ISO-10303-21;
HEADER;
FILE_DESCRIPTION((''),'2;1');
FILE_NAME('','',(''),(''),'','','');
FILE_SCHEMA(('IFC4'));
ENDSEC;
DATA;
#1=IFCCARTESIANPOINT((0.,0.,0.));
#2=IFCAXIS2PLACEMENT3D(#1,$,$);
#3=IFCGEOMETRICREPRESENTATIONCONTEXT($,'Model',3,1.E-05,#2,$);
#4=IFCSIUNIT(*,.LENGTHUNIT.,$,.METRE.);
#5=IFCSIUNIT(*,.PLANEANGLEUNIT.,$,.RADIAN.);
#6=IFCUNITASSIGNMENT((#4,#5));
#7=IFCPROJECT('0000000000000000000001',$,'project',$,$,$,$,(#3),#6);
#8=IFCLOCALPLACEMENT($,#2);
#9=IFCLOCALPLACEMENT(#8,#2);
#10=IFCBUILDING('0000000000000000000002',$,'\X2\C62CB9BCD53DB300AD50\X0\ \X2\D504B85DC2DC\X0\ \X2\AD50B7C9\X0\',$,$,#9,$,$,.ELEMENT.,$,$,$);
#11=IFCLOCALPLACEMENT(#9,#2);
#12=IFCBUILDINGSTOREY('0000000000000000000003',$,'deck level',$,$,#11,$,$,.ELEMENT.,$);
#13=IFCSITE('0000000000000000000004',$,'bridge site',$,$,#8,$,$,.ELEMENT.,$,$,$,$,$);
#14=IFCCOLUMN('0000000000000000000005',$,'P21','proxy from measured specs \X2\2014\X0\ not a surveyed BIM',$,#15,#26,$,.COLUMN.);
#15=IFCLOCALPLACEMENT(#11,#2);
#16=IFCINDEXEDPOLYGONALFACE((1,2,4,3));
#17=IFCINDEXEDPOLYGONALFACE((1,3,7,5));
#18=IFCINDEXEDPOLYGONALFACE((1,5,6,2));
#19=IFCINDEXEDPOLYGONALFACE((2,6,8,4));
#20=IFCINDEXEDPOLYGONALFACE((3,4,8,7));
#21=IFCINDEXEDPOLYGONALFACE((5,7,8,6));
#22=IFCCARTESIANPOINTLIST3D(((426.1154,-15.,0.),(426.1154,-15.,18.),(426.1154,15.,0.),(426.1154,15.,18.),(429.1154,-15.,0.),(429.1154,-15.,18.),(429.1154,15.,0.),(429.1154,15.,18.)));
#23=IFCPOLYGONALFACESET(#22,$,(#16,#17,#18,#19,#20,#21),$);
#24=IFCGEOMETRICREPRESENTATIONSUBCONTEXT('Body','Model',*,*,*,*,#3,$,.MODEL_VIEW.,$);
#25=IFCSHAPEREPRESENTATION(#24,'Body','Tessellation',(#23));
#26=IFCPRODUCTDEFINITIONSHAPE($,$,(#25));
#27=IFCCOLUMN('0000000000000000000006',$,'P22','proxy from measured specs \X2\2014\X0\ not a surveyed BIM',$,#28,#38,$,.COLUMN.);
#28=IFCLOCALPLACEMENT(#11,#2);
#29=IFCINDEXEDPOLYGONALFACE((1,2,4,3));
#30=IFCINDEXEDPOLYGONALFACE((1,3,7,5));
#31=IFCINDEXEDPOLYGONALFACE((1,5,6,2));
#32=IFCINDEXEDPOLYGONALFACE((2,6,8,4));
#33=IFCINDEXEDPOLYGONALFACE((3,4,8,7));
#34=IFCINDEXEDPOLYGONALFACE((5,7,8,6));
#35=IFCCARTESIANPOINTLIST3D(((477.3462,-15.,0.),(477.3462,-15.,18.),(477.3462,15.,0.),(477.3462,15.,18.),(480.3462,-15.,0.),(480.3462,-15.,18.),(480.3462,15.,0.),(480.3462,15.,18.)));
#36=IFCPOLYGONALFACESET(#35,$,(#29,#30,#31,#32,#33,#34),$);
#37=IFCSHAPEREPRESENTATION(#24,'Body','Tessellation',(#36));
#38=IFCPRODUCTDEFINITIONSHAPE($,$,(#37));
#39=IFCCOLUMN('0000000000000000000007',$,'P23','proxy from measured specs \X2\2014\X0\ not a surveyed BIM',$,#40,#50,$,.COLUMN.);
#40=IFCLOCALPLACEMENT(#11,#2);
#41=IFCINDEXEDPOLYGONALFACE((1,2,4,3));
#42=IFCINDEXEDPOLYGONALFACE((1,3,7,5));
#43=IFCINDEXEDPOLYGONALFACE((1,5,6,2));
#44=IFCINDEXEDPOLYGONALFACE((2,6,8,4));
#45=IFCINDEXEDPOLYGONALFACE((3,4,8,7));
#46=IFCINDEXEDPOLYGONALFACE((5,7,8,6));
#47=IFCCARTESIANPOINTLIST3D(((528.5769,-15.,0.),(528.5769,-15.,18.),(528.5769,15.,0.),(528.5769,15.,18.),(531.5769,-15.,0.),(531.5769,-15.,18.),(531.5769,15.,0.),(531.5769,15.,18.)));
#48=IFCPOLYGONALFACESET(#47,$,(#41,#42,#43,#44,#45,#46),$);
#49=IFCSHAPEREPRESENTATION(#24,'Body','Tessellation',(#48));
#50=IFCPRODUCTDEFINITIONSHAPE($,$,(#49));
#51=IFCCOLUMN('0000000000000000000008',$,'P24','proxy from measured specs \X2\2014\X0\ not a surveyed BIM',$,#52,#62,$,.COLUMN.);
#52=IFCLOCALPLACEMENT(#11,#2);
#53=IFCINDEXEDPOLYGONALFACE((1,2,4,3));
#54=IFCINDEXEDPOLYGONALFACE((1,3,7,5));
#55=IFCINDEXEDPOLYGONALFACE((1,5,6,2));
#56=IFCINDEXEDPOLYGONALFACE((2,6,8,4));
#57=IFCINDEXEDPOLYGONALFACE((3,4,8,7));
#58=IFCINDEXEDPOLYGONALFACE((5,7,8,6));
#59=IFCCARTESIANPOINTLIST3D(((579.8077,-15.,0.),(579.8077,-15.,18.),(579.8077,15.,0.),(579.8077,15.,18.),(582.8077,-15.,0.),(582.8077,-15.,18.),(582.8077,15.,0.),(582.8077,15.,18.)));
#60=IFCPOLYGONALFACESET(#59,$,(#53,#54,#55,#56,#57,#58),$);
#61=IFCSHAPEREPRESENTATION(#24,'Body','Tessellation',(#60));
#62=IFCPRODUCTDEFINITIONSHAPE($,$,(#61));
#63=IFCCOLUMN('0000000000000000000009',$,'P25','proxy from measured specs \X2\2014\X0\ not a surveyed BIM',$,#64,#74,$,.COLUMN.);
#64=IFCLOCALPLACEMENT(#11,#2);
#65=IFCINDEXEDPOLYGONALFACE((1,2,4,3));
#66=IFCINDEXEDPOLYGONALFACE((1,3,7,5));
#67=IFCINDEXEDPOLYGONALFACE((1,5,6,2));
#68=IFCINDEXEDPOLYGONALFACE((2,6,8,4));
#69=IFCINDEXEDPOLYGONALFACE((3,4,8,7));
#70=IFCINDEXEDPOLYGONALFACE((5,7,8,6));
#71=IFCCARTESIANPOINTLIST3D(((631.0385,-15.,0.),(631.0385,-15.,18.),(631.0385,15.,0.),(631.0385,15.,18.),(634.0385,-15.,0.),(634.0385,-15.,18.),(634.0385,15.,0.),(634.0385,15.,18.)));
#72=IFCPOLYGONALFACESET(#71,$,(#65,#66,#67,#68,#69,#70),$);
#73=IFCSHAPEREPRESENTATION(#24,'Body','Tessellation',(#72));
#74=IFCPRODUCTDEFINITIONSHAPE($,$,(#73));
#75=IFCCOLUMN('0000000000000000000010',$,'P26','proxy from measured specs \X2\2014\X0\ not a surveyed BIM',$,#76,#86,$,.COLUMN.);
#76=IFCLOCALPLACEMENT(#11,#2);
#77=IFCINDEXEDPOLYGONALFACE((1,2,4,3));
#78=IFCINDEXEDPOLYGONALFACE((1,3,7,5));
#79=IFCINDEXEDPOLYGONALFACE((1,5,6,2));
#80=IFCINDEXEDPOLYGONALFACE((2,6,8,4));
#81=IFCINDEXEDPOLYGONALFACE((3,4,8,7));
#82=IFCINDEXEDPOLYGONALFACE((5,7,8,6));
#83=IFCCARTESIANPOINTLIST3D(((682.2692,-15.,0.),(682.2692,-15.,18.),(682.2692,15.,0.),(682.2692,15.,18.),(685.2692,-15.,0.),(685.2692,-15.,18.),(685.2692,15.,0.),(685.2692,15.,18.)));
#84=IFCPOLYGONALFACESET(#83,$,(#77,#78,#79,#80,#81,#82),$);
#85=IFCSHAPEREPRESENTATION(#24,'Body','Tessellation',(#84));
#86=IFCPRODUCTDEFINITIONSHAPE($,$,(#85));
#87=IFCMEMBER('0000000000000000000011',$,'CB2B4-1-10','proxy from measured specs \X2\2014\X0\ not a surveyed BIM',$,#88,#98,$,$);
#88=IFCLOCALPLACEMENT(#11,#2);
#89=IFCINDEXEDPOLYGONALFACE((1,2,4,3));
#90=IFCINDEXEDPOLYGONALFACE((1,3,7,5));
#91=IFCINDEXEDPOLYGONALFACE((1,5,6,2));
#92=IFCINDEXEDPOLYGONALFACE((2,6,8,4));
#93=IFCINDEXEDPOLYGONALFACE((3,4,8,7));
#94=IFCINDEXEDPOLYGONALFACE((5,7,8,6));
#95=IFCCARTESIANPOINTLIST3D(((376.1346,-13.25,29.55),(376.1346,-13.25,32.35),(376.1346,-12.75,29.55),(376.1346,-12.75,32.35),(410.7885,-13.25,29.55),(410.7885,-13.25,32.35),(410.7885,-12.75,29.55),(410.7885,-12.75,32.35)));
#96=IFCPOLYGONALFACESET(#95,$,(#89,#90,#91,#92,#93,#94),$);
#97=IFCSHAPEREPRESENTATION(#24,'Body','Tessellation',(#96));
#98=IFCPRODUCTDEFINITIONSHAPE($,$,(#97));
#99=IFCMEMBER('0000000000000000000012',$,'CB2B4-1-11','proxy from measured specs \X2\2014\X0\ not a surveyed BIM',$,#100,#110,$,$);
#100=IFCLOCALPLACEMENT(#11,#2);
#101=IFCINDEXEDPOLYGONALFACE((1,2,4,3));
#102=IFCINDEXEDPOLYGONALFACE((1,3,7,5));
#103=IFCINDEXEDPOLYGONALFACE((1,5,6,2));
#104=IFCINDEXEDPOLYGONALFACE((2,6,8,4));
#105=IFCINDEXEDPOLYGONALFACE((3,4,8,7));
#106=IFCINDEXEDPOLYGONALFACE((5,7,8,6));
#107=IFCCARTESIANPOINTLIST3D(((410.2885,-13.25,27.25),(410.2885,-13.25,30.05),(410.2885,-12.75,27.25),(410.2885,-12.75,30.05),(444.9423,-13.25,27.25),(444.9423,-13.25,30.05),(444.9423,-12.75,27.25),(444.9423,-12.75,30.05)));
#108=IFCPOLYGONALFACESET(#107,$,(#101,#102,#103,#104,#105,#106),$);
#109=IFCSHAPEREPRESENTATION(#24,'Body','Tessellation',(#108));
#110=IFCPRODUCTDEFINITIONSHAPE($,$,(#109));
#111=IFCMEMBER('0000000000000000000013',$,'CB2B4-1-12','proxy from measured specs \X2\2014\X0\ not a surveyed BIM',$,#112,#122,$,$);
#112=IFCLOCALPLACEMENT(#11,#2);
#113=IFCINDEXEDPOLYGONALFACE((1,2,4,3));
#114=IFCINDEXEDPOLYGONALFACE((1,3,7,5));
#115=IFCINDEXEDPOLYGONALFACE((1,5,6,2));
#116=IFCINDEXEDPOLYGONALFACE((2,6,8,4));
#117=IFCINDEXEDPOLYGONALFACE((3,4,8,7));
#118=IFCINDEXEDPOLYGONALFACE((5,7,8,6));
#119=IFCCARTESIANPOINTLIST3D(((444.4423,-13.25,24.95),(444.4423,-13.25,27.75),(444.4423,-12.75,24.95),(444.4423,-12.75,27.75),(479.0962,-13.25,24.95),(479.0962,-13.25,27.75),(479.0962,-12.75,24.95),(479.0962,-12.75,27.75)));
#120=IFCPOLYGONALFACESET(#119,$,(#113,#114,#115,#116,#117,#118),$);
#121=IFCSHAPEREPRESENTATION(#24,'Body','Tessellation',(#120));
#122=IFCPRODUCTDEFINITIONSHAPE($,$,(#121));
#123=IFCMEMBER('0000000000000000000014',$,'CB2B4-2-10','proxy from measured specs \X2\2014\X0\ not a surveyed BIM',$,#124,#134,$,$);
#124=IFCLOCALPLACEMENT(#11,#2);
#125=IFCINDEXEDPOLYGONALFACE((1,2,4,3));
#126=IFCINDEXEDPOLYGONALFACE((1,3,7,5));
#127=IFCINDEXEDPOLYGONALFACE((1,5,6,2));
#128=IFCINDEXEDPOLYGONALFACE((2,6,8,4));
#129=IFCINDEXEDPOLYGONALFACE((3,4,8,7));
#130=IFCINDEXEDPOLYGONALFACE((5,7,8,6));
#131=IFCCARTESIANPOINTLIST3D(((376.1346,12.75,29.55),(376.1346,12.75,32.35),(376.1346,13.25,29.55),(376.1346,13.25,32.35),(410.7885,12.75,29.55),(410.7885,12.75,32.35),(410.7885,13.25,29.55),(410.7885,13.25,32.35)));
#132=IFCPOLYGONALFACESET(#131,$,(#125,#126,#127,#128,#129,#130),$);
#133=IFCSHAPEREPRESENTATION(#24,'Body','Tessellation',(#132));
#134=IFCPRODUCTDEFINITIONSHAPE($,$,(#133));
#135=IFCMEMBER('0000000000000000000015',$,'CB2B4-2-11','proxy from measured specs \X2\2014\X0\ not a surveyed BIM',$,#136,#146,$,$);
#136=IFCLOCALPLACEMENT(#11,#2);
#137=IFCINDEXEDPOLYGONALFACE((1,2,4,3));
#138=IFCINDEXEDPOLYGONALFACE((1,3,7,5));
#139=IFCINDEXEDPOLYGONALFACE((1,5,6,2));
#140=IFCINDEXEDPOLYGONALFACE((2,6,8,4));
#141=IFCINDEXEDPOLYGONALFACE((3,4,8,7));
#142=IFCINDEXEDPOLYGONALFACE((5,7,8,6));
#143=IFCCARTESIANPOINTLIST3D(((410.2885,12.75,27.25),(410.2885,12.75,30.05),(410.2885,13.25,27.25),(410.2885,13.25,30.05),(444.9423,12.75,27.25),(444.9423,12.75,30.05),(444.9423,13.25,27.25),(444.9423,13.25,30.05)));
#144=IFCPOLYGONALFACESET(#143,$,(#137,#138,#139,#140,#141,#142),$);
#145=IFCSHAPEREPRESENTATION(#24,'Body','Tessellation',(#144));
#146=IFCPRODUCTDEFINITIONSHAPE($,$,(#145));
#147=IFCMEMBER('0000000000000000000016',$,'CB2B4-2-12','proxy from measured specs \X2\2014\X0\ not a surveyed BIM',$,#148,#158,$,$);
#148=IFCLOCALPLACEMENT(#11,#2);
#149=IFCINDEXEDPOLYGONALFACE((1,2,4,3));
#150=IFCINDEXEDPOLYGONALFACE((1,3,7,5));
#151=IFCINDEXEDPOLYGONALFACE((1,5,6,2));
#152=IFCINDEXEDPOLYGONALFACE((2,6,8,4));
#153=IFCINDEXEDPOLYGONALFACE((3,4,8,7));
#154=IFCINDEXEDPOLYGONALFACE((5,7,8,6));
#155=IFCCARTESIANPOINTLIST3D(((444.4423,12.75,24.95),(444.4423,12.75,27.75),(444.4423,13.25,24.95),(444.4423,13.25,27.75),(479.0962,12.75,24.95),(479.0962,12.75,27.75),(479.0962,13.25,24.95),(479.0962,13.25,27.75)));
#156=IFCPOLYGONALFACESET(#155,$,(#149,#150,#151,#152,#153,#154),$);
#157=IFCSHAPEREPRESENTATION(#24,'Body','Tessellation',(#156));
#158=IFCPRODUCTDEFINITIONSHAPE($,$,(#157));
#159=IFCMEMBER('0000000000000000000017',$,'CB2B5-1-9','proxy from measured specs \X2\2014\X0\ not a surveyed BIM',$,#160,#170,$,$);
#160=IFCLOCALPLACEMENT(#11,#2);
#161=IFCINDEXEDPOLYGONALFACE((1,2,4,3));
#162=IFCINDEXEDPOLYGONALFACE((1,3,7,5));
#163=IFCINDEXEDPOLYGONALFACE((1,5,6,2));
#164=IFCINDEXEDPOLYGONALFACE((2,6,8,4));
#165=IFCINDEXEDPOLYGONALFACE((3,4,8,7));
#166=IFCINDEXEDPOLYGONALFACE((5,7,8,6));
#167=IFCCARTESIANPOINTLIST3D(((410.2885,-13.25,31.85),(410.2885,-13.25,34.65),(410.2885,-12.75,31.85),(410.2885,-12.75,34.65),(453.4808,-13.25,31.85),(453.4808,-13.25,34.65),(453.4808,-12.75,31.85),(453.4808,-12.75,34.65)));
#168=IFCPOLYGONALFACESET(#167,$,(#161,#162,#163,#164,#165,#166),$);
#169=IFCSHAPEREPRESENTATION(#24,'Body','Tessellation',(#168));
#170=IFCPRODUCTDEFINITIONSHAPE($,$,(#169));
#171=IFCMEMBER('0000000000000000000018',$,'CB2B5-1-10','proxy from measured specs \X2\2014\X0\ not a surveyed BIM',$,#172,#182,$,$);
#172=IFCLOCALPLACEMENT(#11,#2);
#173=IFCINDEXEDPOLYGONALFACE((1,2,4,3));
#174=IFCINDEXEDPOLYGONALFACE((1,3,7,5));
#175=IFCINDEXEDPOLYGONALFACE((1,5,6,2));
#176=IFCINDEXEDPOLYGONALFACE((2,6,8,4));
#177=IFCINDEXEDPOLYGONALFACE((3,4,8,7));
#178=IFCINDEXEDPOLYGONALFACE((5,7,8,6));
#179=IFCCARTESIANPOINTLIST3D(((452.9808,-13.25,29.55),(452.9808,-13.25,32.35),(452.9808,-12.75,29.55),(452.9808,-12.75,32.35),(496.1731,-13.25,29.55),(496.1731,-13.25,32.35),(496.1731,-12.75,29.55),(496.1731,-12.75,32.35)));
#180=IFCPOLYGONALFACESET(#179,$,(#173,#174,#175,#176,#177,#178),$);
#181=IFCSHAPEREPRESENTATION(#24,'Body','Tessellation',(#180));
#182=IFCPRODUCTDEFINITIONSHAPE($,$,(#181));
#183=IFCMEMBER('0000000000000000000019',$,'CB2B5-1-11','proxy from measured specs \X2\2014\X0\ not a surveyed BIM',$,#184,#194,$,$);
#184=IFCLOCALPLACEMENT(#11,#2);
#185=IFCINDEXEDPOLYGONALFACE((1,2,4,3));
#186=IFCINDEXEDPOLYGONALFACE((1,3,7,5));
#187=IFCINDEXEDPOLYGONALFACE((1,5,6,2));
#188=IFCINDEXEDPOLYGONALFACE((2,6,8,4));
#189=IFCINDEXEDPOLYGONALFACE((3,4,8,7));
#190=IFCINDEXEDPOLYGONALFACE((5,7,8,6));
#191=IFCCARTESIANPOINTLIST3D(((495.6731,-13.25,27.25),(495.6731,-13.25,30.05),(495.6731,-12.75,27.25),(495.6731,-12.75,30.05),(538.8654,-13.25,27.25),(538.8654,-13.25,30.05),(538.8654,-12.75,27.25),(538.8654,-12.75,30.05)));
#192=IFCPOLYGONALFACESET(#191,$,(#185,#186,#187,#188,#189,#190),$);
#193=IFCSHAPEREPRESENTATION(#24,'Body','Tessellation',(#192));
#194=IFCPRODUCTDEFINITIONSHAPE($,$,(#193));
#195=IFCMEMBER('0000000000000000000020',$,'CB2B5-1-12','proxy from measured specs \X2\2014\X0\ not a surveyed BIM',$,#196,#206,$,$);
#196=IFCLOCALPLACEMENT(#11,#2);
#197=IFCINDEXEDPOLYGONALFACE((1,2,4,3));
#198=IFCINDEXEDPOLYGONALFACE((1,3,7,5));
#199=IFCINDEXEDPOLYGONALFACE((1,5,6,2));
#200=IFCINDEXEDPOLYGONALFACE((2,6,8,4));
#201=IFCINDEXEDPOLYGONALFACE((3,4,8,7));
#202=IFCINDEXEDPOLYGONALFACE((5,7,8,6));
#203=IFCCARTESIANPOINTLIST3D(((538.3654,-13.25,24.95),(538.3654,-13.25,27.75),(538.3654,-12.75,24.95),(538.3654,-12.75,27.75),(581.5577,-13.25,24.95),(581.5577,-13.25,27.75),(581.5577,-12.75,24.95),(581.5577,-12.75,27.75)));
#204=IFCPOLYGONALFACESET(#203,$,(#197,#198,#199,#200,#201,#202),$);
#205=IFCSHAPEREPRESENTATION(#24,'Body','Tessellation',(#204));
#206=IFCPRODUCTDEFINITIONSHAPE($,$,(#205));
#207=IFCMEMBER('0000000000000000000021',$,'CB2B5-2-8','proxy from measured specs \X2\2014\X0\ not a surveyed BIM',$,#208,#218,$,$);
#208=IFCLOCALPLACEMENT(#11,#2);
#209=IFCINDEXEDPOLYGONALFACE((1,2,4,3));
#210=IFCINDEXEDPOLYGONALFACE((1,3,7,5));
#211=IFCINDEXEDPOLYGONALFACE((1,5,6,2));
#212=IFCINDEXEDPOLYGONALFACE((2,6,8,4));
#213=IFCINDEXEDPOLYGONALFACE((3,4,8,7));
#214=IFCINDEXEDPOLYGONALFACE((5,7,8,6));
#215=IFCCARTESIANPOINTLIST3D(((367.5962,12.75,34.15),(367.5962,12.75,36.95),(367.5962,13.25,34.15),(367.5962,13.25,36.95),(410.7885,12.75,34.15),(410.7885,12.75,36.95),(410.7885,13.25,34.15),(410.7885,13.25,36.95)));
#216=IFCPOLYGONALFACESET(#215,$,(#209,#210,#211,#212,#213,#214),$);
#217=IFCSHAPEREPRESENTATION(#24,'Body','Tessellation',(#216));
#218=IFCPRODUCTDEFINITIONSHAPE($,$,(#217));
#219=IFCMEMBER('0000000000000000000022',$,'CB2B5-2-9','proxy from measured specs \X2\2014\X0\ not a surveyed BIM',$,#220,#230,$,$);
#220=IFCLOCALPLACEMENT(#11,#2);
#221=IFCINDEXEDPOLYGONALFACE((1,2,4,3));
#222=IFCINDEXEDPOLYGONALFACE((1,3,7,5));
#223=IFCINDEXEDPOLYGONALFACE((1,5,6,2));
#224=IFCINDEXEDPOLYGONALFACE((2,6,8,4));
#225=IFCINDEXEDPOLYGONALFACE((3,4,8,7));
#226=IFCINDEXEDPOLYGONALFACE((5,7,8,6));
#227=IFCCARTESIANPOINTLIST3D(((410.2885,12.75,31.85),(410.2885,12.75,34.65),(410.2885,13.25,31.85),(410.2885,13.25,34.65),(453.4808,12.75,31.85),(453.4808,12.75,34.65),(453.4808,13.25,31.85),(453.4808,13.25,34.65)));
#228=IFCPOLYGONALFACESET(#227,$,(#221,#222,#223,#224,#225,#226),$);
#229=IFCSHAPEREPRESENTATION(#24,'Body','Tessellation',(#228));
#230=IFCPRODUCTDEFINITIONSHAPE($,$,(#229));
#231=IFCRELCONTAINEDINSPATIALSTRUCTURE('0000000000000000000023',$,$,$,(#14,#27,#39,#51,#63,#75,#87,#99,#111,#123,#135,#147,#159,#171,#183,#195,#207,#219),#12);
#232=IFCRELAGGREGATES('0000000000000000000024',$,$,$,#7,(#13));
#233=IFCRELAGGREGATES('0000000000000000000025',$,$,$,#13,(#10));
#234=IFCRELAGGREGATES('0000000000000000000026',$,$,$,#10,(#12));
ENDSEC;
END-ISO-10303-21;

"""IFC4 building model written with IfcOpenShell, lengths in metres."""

from ifc_helpers import new_model, si_unit, frame, origin, origin_2d, place, context, subcontext, project, spatial, rectangle, extrude, element, save


model = new_model("IFC4")

# Units and contexts
model_context = context("Model", 3, precision=1e-05, world=origin())
body_context = subcontext(model_context, "Body", "Model", "MODEL_VIEW")
ifc_project = project(units=[si_unit("LENGTHUNIT", "METRE"), si_unit("PLANEANGLEUNIT", "RADIAN")], contexts=[model_context])

# Site, building, storey
site_placement = place(None, origin())
site = spatial("IfcSite", under=ifc_project, at=site_placement, Name="bridge site", CompositionType="ELEMENT")
building_placement = place(site_placement, origin())
building = spatial("IfcBuilding", under=site, at=building_placement, Name="올림픽대교 프록시 교량", CompositionType="ELEMENT")
storey_placement = place(building_placement, origin())
storey = spatial("IfcBuildingStorey", under=building, at=storey_placement, Name="deck level", CompositionType="ELEMENT")

# Columns
for number, where, name in (
    (1, (427.6154, 0.0, 0.0), "P21"),
    (2, (478.8462, 0.0, 0.0), "P22"),
    (3, (530.0769, 0.0, 0.0), "P23"),
    (4, (581.3077, 0.0, 0.0), "P24"),
    (5, (632.5385, 0.0, 0.0), "P25"),
    (6, (683.7692, 0.0, 0.0), "P26"),
):
    element("IfcColumn", number, at=place(storey_placement, frame(where)), inside=storey, Name=name, Description="proxy from measured specs — not a surveyed BIM", PredefinedType="COLUMN", context=body_context, shape_type="SweptSolid", body=[
        extrude(rectangle(XDim=3.0, YDim=30.0, at=origin_2d()), origin(), (0.0, 0.0, 1.0), 18.0),
    ])

# Members
member_1_placement = place(storey_placement, frame((393.4615, -13.0, 29.55)))
element("IfcMember", 7, at=member_1_placement, inside=storey, Name="CB2B4-1-10", Description="proxy from measured specs — not a surveyed BIM", context=body_context, shape_type="SweptSolid", body=[
    extrude(rectangle(XDim=34.6538, YDim=0.5, at=origin_2d()), origin(), (0.0, 0.0, 1.0), 2.8),
])
member_2_placement = place(storey_placement, frame((427.6154, -13.0, 27.25)))
element("IfcMember", 8, at=member_2_placement, inside=storey, Name="CB2B4-1-11", Description="proxy from measured specs — not a surveyed BIM", context=body_context, shape_type="SweptSolid", body=[
    extrude(rectangle(XDim=34.6538, YDim=0.5, at=origin_2d()), origin(), (0.0, 0.0, 1.0), 2.8),
])
member_3_placement = place(storey_placement, frame((461.7692, -13.0, 24.95)))
element("IfcMember", 9, at=member_3_placement, inside=storey, Name="CB2B4-1-12", Description="proxy from measured specs — not a surveyed BIM", context=body_context, shape_type="SweptSolid", body=[
    extrude(rectangle(XDim=34.6538, YDim=0.5, at=origin_2d()), origin(), (0.0, 0.0, 1.0), 2.8),
])
member_4_placement = place(storey_placement, frame((393.4615, 13.0, 29.55)))
element("IfcMember", 10, at=member_4_placement, inside=storey, Name="CB2B4-2-10", Description="proxy from measured specs — not a surveyed BIM", context=body_context, shape_type="SweptSolid", body=[
    extrude(rectangle(XDim=34.6538, YDim=0.5, at=origin_2d()), origin(), (0.0, 0.0, 1.0), 2.8),
])
member_5_placement = place(storey_placement, frame((427.6154, 13.0, 27.25)))
element("IfcMember", 11, at=member_5_placement, inside=storey, Name="CB2B4-2-11", Description="proxy from measured specs — not a surveyed BIM", context=body_context, shape_type="SweptSolid", body=[
    extrude(rectangle(XDim=34.6538, YDim=0.5, at=origin_2d()), origin(), (0.0, 0.0, 1.0), 2.8),
])
member_6_placement = place(storey_placement, frame((461.7692, 13.0, 24.95)))
element("IfcMember", 12, at=member_6_placement, inside=storey, Name="CB2B4-2-12", Description="proxy from measured specs — not a surveyed BIM", context=body_context, shape_type="SweptSolid", body=[
    extrude(rectangle(XDim=34.6538, YDim=0.5, at=origin_2d()), origin(), (0.0, 0.0, 1.0), 2.8),
])
member_7_placement = place(storey_placement, frame((431.8846, -13.0, 31.85)))
element("IfcMember", 13, at=member_7_placement, inside=storey, Name="CB2B5-1-9", Description="proxy from measured specs — not a surveyed BIM", context=body_context, shape_type="SweptSolid", body=[
    extrude(rectangle(XDim=43.1923, YDim=0.5, at=origin_2d()), origin(), (0.0, 0.0, 1.0), 2.8),
])
member_8_placement = place(storey_placement, frame((474.5769, -13.0, 29.55)))
element("IfcMember", 14, at=member_8_placement, inside=storey, Name="CB2B5-1-10", Description="proxy from measured specs — not a surveyed BIM", context=body_context, shape_type="SweptSolid", body=[
    extrude(rectangle(XDim=43.1923, YDim=0.5, at=origin_2d()), origin(), (0.0, 0.0, 1.0), 2.8),
])
member_9_placement = place(storey_placement, frame((517.2692, -13.0, 27.25)))
element("IfcMember", 15, at=member_9_placement, inside=storey, Name="CB2B5-1-11", Description="proxy from measured specs — not a surveyed BIM", context=body_context, shape_type="SweptSolid", body=[
    extrude(rectangle(XDim=43.1923, YDim=0.5, at=origin_2d()), origin(), (0.0, 0.0, 1.0), 2.8),
])
member_10_placement = place(storey_placement, frame((559.9615, -13.0, 24.95)))
element("IfcMember", 16, at=member_10_placement, inside=storey, Name="CB2B5-1-12", Description="proxy from measured specs — not a surveyed BIM", context=body_context, shape_type="SweptSolid", body=[
    extrude(rectangle(XDim=43.1923, YDim=0.5, at=origin_2d()), origin(), (0.0, 0.0, 1.0), 2.8),
])
member_11_placement = place(storey_placement, frame((389.1923, 13.0, 34.15)))
element("IfcMember", 17, at=member_11_placement, inside=storey, Name="CB2B5-2-8", Description="proxy from measured specs — not a surveyed BIM", context=body_context, shape_type="SweptSolid", body=[
    extrude(rectangle(XDim=43.1923, YDim=0.5, at=origin_2d()), origin(), (0.0, 0.0, 1.0), 2.8),
])
member_12_placement = place(storey_placement, frame((431.8846, 13.0, 31.85)))
element("IfcMember", 18, at=member_12_placement, inside=storey, Name="CB2B5-2-9", Description="proxy from measured specs — not a surveyed BIM", context=body_context, shape_type="SweptSolid", body=[
    extrude(rectangle(XDim=43.1923, YDim=0.5, at=origin_2d()), origin(), (0.0, 0.0, 1.0), 2.8),
])

save(model, "model.ifc")
